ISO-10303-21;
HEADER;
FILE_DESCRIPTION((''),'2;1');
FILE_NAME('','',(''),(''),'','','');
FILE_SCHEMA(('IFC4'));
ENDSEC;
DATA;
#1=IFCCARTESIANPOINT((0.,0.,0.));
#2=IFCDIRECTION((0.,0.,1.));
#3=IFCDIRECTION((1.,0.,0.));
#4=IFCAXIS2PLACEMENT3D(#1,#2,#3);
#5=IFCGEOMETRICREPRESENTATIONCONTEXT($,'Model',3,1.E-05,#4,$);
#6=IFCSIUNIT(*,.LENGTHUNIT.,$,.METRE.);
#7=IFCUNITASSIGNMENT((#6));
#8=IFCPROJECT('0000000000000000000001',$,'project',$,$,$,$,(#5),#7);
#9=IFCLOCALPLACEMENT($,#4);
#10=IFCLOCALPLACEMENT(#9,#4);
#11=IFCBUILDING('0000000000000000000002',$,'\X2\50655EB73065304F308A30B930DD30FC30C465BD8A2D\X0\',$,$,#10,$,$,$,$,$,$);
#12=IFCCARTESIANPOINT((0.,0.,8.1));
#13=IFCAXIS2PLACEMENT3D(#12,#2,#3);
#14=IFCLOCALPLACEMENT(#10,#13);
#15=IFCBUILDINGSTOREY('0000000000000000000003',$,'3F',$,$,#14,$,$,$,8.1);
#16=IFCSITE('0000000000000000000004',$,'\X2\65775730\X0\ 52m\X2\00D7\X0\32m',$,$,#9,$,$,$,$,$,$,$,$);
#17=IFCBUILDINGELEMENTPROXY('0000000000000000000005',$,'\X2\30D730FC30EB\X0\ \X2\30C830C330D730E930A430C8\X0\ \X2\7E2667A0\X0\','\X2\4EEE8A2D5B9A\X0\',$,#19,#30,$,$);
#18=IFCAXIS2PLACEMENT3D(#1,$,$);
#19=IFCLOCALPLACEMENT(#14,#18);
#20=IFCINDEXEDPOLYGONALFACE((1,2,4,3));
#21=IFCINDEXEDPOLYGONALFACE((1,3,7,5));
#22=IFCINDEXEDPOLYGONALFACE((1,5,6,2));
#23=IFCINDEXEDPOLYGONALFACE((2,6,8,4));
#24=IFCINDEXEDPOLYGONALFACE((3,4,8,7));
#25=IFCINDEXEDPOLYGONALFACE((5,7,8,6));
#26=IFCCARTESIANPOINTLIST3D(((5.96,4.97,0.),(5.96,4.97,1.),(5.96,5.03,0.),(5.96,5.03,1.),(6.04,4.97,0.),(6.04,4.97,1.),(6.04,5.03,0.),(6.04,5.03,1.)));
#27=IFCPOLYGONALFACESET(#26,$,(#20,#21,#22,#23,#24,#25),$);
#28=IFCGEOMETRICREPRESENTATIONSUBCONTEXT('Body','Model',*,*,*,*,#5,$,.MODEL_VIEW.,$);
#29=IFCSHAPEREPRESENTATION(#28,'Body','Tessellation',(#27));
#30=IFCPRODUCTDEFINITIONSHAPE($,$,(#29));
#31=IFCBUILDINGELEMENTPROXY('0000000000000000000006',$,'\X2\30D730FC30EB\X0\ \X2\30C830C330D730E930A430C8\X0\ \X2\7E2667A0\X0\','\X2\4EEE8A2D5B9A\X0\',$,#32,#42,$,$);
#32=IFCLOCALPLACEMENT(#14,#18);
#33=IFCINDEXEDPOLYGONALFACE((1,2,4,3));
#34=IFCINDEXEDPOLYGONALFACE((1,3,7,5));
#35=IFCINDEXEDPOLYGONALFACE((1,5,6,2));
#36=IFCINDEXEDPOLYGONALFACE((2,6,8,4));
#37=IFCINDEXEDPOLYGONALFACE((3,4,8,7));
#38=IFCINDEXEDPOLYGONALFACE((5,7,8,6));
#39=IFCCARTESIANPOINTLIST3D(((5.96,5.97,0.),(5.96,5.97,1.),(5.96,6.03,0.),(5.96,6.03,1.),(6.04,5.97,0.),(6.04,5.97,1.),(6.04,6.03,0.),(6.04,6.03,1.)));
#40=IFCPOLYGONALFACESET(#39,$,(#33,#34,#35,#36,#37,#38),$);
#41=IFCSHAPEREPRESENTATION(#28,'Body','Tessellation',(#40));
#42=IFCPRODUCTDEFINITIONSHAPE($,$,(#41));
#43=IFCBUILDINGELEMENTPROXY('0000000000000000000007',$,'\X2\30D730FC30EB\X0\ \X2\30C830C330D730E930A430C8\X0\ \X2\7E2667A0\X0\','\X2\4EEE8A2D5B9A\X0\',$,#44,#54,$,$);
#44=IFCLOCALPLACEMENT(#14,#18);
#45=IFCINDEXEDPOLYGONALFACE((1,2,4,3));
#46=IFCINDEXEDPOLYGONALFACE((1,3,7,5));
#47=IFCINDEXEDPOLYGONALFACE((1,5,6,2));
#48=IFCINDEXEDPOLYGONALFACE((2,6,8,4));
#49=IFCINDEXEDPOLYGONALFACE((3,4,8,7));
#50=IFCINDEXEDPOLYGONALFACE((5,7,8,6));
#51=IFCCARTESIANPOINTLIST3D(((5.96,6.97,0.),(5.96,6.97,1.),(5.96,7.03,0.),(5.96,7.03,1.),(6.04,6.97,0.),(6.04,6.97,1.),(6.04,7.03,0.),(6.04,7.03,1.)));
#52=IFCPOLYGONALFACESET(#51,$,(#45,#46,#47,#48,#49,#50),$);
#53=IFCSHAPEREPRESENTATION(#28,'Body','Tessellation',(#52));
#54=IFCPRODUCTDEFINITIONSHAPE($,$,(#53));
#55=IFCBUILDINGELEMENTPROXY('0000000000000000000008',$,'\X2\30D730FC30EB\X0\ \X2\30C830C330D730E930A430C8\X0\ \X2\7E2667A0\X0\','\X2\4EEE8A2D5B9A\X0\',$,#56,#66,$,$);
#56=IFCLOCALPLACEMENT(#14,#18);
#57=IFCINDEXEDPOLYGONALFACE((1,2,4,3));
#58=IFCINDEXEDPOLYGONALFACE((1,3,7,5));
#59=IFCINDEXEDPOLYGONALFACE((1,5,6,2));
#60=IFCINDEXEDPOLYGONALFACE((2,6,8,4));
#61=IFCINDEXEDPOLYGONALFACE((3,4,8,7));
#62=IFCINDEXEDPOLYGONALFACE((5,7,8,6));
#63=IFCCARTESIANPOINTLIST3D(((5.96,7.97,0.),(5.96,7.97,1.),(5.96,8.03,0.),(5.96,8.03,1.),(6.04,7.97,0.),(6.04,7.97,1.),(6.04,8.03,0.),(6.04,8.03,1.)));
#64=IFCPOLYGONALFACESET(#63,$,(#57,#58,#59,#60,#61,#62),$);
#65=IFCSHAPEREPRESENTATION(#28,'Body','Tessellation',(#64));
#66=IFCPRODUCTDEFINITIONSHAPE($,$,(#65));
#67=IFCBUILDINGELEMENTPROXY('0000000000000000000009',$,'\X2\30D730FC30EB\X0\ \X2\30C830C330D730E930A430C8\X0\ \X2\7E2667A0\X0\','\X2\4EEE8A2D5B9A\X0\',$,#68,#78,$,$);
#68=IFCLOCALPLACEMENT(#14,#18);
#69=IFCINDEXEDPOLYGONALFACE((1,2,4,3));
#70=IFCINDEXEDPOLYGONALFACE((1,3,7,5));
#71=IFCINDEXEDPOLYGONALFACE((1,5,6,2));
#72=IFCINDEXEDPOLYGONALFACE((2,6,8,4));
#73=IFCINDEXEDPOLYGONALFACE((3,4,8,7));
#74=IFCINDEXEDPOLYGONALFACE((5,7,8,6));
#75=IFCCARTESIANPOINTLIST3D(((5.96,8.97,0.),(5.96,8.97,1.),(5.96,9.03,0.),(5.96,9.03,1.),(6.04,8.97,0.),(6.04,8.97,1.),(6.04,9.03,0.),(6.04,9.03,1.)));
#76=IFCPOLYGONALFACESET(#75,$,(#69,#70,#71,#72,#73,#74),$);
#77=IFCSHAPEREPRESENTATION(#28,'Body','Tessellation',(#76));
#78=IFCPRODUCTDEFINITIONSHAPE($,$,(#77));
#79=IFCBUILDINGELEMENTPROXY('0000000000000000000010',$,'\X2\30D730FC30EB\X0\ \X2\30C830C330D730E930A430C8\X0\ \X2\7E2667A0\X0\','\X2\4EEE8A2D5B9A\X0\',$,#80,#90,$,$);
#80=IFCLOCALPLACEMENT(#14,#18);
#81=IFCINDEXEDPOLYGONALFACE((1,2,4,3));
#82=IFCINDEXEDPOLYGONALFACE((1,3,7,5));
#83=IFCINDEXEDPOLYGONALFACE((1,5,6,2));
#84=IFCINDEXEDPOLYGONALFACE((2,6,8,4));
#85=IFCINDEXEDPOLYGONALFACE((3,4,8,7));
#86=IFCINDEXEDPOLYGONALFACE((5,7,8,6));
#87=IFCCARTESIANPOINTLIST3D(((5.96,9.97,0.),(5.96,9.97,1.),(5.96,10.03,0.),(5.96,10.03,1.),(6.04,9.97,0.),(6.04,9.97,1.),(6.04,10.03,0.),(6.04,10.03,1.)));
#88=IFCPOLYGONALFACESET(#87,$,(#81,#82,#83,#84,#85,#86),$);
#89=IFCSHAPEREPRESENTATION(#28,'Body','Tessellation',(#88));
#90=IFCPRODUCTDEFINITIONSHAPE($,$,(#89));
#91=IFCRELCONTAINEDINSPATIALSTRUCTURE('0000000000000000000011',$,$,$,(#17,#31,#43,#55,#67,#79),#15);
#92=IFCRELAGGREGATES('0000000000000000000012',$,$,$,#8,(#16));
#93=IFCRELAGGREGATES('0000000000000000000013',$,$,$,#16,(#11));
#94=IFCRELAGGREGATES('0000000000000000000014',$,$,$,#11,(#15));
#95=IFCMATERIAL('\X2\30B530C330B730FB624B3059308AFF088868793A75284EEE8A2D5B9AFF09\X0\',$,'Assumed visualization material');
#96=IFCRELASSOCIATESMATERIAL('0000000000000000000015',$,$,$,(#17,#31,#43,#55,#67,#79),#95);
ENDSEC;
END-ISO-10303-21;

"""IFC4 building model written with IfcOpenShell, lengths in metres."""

from ifc_helpers import new_model, si_unit, frame, origin_with_axes, place, context, subcontext, project, spatial, rectangle, extrude, material, element, save


model = new_model("IFC4")

# Units and contexts
model_context = context("Model", 3, precision=1e-05, world=origin_with_axes())
body_context = subcontext(model_context, "Body", "Model", "MODEL_VIEW")
ifc_project = project(units=[si_unit("LENGTHUNIT", "METRE")], contexts=[model_context])

# Site, building, storey
site_placement = place(None, origin_with_axes())
site = spatial("IfcSite", under=ifc_project, at=site_placement, Name="敷地 52m×32m")
building_placement = place(site_placement, origin_with_axes())
building = spatial("IfcBuilding", under=site, at=building_placement, Name="健康づくりスポーツ施設")
storey_placement = place(building_placement, frame((0.0, 0.0, 8.1), z_axis=(0.0, 0.0, 1.0), x_axis=(1.0, 0.0, 0.0)))
storey = spatial("IfcBuildingStorey", under=building, at=storey_placement, Name="3F", Elevation=8.1)

# Shared definitions
ifc_material_1 = material(Name="サッシ・手すり（表示用仮設定）", Category="Assumed visualization material")

# Building element proxies
for number, where, z_axis, x_axis, name in (
    (1, (6.0, 5.0, 0.0), (0.0, 0.0, 1.0), (1.0, 0.0, 0.0), "プール トップライト 縦枠"),
    (2, (6.0, 6.0, 0.0), (0.0, 0.0, 1.0), (1.0, 0.0, 0.0), "プール トップライト 縦枠"),
    (3, (6.0, 7.0, 0.0), (0.0, 0.0, 1.0), (1.0, 0.0, 0.0), "プール トップライト 縦枠"),
    (4, (6.0, 8.0, 0.0), (0.0, 0.0, 1.0), (1.0, 0.0, 0.0), "プール トップライト 縦枠"),
    (5, (6.0, 9.0, 0.0), (0.0, 0.0, 1.0), (1.0, 0.0, 0.0), "プール トップライト 縦枠"),
    (6, (6.0, 10.0, 0.0), (0.0, 0.0, 1.0), (1.0, 0.0, 0.0), "プール トップライト 縦枠"),
):
    element("IfcBuildingElementProxy", number, at=place(storey_placement, frame(where, z_axis=z_axis, x_axis=x_axis)), inside=storey, material=ifc_material_1, Name=name, Description="仮設定", context=body_context, shape_type="SweptSolid", body=[
        extrude(rectangle(XDim=0.08, YDim=0.06), origin_with_axes(), (0.0, 0.0, 1.0), 1.0),
    ])

save(model, "model.ifc")
